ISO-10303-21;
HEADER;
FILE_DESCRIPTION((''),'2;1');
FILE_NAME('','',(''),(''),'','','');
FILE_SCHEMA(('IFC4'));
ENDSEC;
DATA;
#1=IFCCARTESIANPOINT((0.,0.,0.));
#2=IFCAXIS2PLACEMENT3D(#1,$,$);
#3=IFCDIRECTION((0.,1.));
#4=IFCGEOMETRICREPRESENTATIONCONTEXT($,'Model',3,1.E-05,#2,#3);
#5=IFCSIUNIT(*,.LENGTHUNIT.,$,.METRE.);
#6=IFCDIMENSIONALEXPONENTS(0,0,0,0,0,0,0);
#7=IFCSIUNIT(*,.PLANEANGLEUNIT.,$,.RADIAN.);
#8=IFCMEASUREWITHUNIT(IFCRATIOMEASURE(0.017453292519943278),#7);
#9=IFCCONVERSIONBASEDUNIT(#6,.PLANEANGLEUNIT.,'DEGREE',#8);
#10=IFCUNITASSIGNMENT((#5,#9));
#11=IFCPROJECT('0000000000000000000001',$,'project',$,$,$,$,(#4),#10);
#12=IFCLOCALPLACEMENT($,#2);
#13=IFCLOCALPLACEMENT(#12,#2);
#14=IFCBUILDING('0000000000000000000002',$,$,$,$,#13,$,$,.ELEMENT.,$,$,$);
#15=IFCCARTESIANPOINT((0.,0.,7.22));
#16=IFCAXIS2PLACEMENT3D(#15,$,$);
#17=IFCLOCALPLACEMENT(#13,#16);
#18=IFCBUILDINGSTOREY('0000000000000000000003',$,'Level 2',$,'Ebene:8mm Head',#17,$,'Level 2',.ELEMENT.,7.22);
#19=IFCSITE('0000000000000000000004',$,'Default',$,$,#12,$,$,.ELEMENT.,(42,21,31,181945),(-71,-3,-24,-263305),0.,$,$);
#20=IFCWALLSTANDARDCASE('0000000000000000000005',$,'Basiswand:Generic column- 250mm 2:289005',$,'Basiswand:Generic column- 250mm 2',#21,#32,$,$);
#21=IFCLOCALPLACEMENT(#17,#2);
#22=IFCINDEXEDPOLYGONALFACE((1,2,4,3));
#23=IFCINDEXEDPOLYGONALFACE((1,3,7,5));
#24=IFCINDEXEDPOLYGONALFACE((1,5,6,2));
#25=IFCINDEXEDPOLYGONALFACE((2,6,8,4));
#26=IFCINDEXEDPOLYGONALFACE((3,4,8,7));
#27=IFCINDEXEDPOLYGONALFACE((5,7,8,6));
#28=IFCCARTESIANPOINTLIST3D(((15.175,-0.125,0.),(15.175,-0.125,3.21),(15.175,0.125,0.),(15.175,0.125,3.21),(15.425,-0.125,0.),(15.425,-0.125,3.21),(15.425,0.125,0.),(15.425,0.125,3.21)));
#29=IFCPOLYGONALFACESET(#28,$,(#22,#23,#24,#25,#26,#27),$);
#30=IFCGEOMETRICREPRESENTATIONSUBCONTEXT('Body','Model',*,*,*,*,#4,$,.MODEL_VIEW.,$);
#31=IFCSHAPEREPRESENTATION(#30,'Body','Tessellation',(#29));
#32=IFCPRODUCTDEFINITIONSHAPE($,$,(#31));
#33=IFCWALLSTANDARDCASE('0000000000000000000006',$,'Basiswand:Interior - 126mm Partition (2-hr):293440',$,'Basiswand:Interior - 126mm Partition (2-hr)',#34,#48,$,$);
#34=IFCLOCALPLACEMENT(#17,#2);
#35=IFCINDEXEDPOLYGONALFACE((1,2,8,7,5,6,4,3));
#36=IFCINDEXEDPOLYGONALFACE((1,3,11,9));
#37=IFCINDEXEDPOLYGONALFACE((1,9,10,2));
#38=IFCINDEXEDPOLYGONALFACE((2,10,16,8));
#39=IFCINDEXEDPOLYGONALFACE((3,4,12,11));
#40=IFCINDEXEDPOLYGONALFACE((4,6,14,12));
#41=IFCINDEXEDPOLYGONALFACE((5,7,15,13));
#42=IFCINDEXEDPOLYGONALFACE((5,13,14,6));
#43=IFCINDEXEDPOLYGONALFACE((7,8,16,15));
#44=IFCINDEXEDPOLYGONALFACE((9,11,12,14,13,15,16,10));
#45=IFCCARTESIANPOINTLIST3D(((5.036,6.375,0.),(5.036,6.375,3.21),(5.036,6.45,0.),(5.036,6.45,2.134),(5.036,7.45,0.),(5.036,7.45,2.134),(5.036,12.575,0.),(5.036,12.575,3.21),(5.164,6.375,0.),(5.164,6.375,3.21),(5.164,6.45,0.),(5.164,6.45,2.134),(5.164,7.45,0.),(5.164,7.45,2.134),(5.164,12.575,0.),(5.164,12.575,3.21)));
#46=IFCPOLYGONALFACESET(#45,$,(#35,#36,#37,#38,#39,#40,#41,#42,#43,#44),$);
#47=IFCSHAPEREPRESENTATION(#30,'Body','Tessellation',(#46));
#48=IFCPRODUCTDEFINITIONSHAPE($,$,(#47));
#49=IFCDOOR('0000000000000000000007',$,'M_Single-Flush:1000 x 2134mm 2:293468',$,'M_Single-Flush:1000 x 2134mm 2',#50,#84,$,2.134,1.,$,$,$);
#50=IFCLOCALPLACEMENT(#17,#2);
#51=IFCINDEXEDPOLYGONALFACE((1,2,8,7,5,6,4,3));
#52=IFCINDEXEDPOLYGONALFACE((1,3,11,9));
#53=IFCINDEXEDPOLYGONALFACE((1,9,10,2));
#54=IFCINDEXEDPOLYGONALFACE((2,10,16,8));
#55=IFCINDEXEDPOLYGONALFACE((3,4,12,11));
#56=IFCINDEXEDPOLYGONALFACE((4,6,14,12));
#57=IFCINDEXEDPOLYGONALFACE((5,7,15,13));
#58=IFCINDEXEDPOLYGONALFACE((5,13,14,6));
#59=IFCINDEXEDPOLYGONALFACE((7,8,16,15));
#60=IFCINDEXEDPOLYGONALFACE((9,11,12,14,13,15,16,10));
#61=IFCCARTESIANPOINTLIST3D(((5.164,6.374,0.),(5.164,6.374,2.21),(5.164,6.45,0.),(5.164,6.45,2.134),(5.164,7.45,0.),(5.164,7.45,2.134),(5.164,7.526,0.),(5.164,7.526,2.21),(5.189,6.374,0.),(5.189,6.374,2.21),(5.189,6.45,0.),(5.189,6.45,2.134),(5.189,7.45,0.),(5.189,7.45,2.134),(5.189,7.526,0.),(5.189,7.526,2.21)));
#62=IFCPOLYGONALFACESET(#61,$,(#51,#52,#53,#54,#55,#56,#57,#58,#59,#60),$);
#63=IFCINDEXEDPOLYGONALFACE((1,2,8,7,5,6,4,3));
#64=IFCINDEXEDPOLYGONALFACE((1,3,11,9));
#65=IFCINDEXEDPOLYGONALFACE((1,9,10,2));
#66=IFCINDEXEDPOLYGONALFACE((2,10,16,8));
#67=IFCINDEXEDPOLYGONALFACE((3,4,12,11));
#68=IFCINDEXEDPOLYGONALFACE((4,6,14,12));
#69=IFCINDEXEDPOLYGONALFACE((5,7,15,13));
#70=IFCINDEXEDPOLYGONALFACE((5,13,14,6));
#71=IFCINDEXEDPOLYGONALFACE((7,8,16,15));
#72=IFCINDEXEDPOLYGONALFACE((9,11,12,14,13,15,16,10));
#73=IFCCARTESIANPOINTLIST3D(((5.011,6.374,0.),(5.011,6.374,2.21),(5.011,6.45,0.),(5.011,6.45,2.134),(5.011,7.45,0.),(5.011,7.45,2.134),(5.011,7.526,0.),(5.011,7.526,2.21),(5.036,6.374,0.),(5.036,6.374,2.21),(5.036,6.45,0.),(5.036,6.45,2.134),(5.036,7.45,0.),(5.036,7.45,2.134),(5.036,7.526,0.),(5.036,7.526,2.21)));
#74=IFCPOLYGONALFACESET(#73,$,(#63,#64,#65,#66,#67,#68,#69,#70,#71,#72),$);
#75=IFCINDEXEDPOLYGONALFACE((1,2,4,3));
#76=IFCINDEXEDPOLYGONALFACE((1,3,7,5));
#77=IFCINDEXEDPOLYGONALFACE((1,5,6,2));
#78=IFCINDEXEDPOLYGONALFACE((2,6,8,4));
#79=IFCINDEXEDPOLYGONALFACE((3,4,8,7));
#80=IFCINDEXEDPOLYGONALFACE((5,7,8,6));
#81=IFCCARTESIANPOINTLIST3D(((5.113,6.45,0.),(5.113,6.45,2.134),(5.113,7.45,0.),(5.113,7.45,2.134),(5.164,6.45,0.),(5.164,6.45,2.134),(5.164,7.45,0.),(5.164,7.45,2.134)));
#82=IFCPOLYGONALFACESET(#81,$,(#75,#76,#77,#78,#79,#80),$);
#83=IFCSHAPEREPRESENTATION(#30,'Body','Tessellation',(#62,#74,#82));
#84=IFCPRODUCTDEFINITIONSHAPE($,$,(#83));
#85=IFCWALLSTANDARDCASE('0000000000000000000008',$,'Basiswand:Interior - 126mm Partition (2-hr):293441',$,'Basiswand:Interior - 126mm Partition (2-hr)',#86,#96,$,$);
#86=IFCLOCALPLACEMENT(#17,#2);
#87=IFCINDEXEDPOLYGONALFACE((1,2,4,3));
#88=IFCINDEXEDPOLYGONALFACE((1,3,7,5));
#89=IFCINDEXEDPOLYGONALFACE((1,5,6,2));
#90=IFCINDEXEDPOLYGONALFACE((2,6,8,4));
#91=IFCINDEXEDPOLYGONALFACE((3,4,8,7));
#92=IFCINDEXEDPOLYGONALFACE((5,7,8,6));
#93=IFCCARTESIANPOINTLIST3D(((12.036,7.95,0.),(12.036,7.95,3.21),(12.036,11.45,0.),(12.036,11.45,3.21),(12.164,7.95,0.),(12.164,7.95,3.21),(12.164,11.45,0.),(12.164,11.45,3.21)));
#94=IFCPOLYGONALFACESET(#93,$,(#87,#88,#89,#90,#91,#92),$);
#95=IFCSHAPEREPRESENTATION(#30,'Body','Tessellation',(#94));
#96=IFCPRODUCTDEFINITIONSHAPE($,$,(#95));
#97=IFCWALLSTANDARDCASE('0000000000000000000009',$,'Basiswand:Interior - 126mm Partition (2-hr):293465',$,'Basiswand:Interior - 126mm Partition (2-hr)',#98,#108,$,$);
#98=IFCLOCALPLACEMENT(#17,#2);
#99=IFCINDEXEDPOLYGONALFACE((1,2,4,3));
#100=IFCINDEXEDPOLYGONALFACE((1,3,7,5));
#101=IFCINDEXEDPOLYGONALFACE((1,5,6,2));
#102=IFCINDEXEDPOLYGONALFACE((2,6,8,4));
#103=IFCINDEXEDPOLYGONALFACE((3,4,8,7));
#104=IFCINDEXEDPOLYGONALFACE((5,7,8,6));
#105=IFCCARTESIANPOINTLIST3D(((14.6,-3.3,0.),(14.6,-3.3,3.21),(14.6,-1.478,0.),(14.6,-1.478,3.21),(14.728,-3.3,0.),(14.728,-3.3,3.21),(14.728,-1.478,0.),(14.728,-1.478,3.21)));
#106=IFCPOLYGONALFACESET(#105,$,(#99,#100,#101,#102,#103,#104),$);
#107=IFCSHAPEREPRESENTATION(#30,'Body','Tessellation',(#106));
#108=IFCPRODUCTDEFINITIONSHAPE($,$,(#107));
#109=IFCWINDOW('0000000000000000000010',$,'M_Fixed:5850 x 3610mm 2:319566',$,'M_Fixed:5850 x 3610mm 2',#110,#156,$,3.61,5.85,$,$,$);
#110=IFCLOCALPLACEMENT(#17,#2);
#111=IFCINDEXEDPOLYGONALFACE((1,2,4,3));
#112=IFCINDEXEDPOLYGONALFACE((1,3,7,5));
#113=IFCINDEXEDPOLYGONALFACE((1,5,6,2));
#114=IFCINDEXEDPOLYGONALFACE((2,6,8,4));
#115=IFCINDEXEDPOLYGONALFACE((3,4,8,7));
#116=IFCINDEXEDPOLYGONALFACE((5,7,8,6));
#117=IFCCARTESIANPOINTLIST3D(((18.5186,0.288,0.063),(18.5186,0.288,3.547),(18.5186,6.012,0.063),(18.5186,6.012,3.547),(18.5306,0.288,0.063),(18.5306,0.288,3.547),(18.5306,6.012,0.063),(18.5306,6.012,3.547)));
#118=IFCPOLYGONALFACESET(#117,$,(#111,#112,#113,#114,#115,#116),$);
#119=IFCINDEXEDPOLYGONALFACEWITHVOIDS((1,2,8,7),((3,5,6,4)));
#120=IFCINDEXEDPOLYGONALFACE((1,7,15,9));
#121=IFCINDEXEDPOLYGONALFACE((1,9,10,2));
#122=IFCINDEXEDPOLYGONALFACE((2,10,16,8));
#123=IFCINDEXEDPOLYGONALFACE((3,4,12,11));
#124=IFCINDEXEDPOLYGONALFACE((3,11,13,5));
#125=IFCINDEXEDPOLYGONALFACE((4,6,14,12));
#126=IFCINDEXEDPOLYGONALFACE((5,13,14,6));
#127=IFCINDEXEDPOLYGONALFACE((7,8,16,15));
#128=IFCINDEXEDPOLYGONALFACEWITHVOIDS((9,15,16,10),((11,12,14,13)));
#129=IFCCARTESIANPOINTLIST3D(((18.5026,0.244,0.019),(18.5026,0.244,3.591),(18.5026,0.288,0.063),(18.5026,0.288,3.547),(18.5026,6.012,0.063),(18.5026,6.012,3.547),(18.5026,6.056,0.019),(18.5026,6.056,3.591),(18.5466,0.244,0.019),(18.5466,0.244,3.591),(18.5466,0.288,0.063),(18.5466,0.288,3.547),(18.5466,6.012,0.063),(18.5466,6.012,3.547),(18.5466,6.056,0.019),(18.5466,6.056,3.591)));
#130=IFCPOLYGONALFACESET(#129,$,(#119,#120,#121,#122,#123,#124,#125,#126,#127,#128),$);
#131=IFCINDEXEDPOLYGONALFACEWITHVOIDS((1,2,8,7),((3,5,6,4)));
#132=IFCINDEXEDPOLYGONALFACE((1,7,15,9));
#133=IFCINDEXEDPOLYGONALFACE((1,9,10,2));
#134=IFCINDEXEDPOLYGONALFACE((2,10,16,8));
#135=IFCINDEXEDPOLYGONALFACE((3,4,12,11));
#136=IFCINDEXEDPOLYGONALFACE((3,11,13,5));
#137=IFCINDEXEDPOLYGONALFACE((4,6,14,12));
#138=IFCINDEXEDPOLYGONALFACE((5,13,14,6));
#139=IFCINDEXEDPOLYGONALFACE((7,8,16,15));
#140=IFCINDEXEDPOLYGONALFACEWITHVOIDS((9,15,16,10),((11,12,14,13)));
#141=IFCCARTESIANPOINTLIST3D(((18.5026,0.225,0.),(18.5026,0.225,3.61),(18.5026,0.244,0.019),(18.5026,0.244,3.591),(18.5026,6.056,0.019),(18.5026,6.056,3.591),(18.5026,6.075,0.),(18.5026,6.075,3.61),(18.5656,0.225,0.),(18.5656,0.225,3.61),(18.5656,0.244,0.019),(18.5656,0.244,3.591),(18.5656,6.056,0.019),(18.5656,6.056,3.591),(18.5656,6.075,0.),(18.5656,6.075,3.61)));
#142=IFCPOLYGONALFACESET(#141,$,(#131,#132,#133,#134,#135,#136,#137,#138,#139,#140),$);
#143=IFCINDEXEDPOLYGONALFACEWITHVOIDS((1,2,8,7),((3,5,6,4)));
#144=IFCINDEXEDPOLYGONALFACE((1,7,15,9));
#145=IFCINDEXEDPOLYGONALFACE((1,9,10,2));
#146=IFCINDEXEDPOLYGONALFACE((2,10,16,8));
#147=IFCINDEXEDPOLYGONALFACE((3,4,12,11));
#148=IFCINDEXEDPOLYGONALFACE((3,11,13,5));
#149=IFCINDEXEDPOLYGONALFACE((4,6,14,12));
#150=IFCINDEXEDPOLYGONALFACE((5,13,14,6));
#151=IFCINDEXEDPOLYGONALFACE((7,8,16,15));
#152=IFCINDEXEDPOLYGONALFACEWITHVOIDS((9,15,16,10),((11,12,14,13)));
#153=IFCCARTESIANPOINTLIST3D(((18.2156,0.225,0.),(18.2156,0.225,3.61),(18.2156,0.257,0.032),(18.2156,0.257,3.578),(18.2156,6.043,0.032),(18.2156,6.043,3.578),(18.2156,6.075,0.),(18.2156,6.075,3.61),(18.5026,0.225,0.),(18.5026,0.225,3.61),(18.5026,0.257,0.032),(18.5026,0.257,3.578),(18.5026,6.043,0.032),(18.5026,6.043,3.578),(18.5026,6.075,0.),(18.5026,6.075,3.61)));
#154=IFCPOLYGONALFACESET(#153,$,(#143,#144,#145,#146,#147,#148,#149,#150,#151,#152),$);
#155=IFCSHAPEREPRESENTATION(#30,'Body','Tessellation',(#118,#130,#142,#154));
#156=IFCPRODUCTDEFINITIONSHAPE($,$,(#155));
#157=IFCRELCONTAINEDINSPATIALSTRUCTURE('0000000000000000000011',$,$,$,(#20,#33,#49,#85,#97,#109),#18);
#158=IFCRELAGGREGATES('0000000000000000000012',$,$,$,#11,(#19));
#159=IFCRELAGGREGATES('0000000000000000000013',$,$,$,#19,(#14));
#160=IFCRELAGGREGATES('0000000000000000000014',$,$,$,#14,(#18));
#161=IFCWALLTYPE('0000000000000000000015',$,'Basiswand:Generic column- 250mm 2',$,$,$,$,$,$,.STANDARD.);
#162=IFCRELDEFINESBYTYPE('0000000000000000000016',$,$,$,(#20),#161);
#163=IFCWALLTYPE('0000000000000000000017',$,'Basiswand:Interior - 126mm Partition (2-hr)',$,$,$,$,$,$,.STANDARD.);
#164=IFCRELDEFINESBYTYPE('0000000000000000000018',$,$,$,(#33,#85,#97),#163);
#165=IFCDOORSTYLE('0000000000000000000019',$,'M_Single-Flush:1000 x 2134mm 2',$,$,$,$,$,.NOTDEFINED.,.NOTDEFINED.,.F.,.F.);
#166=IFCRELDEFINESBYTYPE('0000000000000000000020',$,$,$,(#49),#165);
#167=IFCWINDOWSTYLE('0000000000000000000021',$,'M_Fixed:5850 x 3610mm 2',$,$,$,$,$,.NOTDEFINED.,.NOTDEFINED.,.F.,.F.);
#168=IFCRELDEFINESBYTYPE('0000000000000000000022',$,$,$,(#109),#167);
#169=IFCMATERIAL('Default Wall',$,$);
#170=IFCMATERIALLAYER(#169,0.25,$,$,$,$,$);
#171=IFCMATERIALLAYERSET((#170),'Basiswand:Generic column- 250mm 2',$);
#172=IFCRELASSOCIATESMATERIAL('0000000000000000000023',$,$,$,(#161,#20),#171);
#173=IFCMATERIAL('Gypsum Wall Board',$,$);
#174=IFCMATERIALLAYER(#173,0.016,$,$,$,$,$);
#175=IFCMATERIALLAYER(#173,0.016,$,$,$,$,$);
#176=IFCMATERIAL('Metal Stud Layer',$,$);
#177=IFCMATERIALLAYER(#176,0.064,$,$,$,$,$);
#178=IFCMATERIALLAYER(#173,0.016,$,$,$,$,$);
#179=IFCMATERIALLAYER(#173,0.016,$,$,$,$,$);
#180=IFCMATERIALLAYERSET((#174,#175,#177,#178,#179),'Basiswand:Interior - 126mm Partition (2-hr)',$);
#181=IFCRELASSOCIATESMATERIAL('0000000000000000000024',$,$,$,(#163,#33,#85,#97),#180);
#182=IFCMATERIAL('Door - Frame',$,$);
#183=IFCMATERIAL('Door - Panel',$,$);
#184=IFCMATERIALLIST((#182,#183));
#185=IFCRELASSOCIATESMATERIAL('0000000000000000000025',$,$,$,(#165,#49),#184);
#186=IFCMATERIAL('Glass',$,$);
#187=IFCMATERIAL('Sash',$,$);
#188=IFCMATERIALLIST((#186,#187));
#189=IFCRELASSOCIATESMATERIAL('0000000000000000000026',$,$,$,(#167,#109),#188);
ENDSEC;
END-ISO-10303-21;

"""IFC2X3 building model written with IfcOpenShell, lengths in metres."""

from ifc_helpers import new_model, entity, si_unit, converted_unit, direction, frame, frame_2d, origin, place, context, subcontext, project, spatial, polyline, rectangle, outline, extrude, clip, bounded_halfspace, source, transform, mapped, material, material_list, layer, layer_set, layer_usage, type_object, type_shapes, element, fill, save


model = new_model("IFC2X3")

# Units and contexts
model_context = context("Model", 3, precision=1e-05, world=origin(), true_north=direction((0.0, 1.0)))
body_context = subcontext(model_context, "Body", "Model", "MODEL_VIEW")
ifc_project = project(units=[si_unit("LENGTHUNIT", "METRE"), converted_unit("PLANEANGLEUNIT", "DEGREE", entity("IfcRatioMeasure", 0.017453292519943278), si_unit("PLANEANGLEUNIT", "RADIAN"), dimensions=[0, 0, 0, 0, 0, 0, 0])], contexts=[model_context])

# Site, building, storey
site_placement = place(None, origin())
site = spatial("IfcSite", under=ifc_project, at=site_placement, Name="Default", CompositionType="ELEMENT", RefLatitude=(42, 21, 31, 181945), RefLongitude=(-71, -3, -24, -263305), RefElevation=0.0)
building_placement = place(site_placement, origin())
building = spatial("IfcBuilding", under=site, at=building_placement, CompositionType="ELEMENT")
storey_placement = place(building_placement, frame((0.0, 0.0, 7.22)))
storey = spatial("IfcBuildingStorey", under=building, at=storey_placement, Name="Level 2", ObjectType="Ebene:8mm Head", LongName="Level 2", CompositionType="ELEMENT", Elevation=7.22)

# Shared definitions
ifc_material_1 = material(Name="Default Wall")
ifc_material_2 = material(Name="Door - Frame")
ifc_material_3 = material(Name="Door - Panel")
ifc_material_list_1 = material_list([ifc_material_2, ifc_material_3])

# Wall
ifc_layer_1 = layer(ifc_material_1, 0.25)
ifc_layer_set_1 = layer_set([ifc_layer_1], Name="Basiswand:Generic column- 250mm 2")
ifc_layer_usage_1 = layer_usage(ifc_layer_set_1, "AXIS2", "NEGATIVE", 0.125)
wall_type_1 = type_object("IfcWallType", Name="Basiswand:Generic column- 250mm 2", PredefinedType="STANDARD", material=ifc_layer_set_1)
for number, where, name in (
    (1, (15.175, 0.0, 0.0), "Basiswand:Generic column- 250mm 2:289005"),
):
    element("IfcWallStandardCase", number, at=place(storey_placement, frame(where)), inside=storey, type_object=wall_type_1, material=ifc_layer_usage_1, Name=name, ObjectType="Basiswand:Generic column- 250mm 2", context=body_context, shape_type="Clipping", body=[
        clip(extrude(rectangle(XDim=0.25, YDim=0.25, at=frame_2d((0.125, 0.0), x_axis=(-1.0, 0.0))), origin(), (0.0, 0.0, 1.0), 3.21), bounded_halfspace(frame((0.0, -0.125, 3.21), z_axis=(0.0, 0.0, -1.0), x_axis=(0.0, 1.0, 0.0)), True, frame((0.0, -0.125, 3.21), z_axis=(0.0, 0.0, -1.0), x_axis=(0.0, 1.0, 0.0)), polyline([(0.0, 0.0), (0.25, 0.0), (0.25, 0.25), (0.0, 0.25), (0.0, 0.0)]))),
    ])

# Wall, opening, door
ifc_material_4 = material(Name="Gypsum Wall Board")
ifc_layer_2 = layer(ifc_material_4, 0.016)
ifc_layer_3 = layer(ifc_material_4, 0.016)
ifc_material_5 = material(Name="Metal Stud Layer")
ifc_layer_4 = layer(ifc_material_5, 0.064)
ifc_layer_5 = layer(ifc_material_4, 0.016)
ifc_layer_6 = layer(ifc_material_4, 0.016)
ifc_layer_set_2 = layer_set([ifc_layer_2, ifc_layer_3, ifc_layer_4, ifc_layer_5, ifc_layer_6], Name="Basiswand:Interior - 126mm Partition (2-hr)")
ifc_layer_usage_2 = layer_usage(ifc_layer_set_2, "AXIS2", "NEGATIVE", 0.064)
wall_type_2 = type_object("IfcWallType", Name="Basiswand:Interior - 126mm Partition (2-hr)", PredefinedType="STANDARD", material=ifc_layer_set_2)
wall_1_placement = place(storey_placement, frame((5.1, 6.375, 0.0), z_axis=(0.0, 0.0, 1.0), x_axis=(0.0, 1.0, 0.0)))
wall_1 = element("IfcWallStandardCase", 2, at=wall_1_placement, inside=storey, type_object=wall_type_2, material=ifc_layer_usage_2, Name="Basiswand:Interior - 126mm Partition (2-hr):293440", ObjectType="Basiswand:Interior - 126mm Partition (2-hr)", context=body_context, shape_type="Clipping", body=[
    clip(extrude(rectangle(XDim=6.2, YDim=0.128, at=frame_2d((3.1, 0.0), x_axis=(1.0, 0.0))), origin(), (0.0, 0.0, 1.0), 3.21), bounded_halfspace(frame((0.0, -0.064, 3.21), z_axis=(0.0, 0.0, -1.0), x_axis=(1.0, 0.0, 0.0)), True, frame((0.0, -0.064, 3.21)), polyline([(0.0, 0.0), (6.2, 0.0), (6.2, 0.128), (0.0, 0.128), (0.0, 0.0)]))),
])
opening_1_placement = place(wall_1_placement, frame((1.075, 0.064, 0.0)))
opening_1 = element("IfcOpeningElement", 3, at=opening_1_placement, cuts=wall_1, ObjectType="Opening", context=body_context, shape_type="SweptSolid", body=[
    extrude(rectangle(XDim=1.0, YDim=2.134, at=frame_2d((1.067, 0.5), x_axis=(0.0, 1.0))), frame((0.0, 0.0, 0.0), z_axis=(0.0, -1.0, 0.0), x_axis=(0.0, 0.0, 1.0)), (0.0, 0.0, 1.0), 0.128),
])
door_style_1 = type_object("IfcDoorStyle", Name="M_Single-Flush:1000 x 2134mm 2", ConstructionType="NOTDEFINED", OperationType="NOTDEFINED", ParameterTakesPrecedence=False, Sizeable=False, material=ifc_material_list_1)
shared_shape_1 = source(origin(), body_context, "Body", "SweptSolid", [
    extrude(outline(polyline([(-0.576, -1.124), (0.576, -1.124), (0.576, 1.086), (0.5, 1.086), (0.5, -1.048), (-0.5, -1.048), (-0.5, 1.086), (-0.576, 1.086), (-0.576, -1.124)])), frame((0.5, 0.128, 1.086), z_axis=(0.0, 1.0, 0.0), x_axis=(1.0, 0.0, 0.0)), (0.0, 0.0, 1.0), 0.025),
    extrude(outline(polyline([(-1.124, -0.576), (1.086, -0.576), (1.086, -0.5), (-1.048, -0.5), (-1.048, 0.5), (1.086, 0.5), (1.086, 0.576), (-1.124, 0.576), (-1.124, -0.576)])), frame((0.5, -0.025, 1.086), z_axis=(0.0, 1.0, 0.0), x_axis=(0.0, 0.0, -1.0)), (0.0, 0.0, 1.0), 0.025),
    extrude(rectangle(XDim=0.051, YDim=1.0, at=frame_2d((0.0, 0.0), x_axis=(1.0, 0.0))), frame((0.5, 0.1025, 0.0), z_axis=(0.0, 0.0, 1.0), x_axis=(0.0, 1.0, 0.0)), (0.0, 0.0, 1.0), 2.134),
])
type_shapes(door_style_1, [shared_shape_1])
door_1_placement = place(opening_1_placement, frame((0.0, 0.0, 0.0), z_axis=(0.0, 0.0, 1.0), x_axis=(-1.0, 0.0, 0.0)))
door_1 = element("IfcDoor", 4, at=door_1_placement, inside=storey, type_object=door_style_1, material=ifc_material_list_1, Name="M_Single-Flush:1000 x 2134mm 2:293468", ObjectType="M_Single-Flush:1000 x 2134mm 2", OverallHeight=2.134, OverallWidth=1.0, context=body_context, shape_type="MappedRepresentation", body=[
    mapped(shared_shape_1, transform((0.0, 0.0, 0.0), scale=1.0)),
])
fill(opening_1, door_1)

# Wall
wall_2_placement = place(storey_placement, frame((12.1, 7.95, 0.0), z_axis=(0.0, 0.0, 1.0), x_axis=(0.0, 1.0, 0.0)))
element("IfcWallStandardCase", 5, at=wall_2_placement, inside=storey, type_object=wall_type_2, material=ifc_layer_usage_2, Name="Basiswand:Interior - 126mm Partition (2-hr):293441", ObjectType="Basiswand:Interior - 126mm Partition (2-hr)", context=body_context, shape_type="Clipping", body=[
    clip(extrude(rectangle(XDim=3.5, YDim=0.128, at=frame_2d((1.75, 0.0), x_axis=(-1.0, 0.0))), origin(), (0.0, 0.0, 1.0), 3.21), bounded_halfspace(frame((0.0, -0.064, 3.21), z_axis=(0.0, 0.0, -1.0), x_axis=(1.0, 0.0, 0.0)), True, frame((0.0, -0.064, 3.21)), polyline([(0.0, 0.0), (3.5, 0.0), (3.5, 0.128), (0.0, 0.128), (0.0, 0.0)]))),
])

# Wall
wall_3_placement = place(storey_placement, frame((14.664, -3.3, 0.0), z_axis=(0.0, 0.0, 1.0), x_axis=(0.0, 1.0, 0.0)))
element("IfcWallStandardCase", 6, at=wall_3_placement, inside=storey, type_object=wall_type_2, material=ifc_layer_usage_2, Name="Basiswand:Interior - 126mm Partition (2-hr):293465", ObjectType="Basiswand:Interior - 126mm Partition (2-hr)", context=body_context, shape_type="Clipping", body=[
    clip(extrude(rectangle(XDim=1.822, YDim=0.128, at=frame_2d((0.911, 0.0), x_axis=(-1.0, 0.0))), origin(), (0.0, 0.0, 1.0), 3.21), bounded_halfspace(frame((0.0, -0.064, 3.21), z_axis=(0.0, 0.0, -1.0), x_axis=(1.0, 0.0, 0.0)), True, frame((0.0, -0.064, 3.21)), polyline([(0.0, 0.0), (1.822, 0.0), (1.822, 0.128), (0.0, 0.128), (0.0, 0.0)]))),
])

# Window
ifc_material_6 = material(Name="Glass")
ifc_material_7 = material(Name="Sash")
ifc_material_list_2 = material_list([ifc_material_6, ifc_material_7])
window_style = type_object("IfcWindowStyle", Name="M_Fixed:5850 x 3610mm 2", ConstructionType="NOTDEFINED", OperationType="NOTDEFINED", ParameterTakesPrecedence=False, Sizeable=False, material=ifc_material_list_2)
shared_shape_2 = source(origin(), body_context, "Body", "SweptSolid", [
    extrude(rectangle(XDim=0.012, YDim=5.724, at=frame_2d((0.0, 0.0), x_axis=(1.0, 0.0))), frame((2.925, 0.309, 0.063), z_axis=(0.0, 0.0, 1.0), x_axis=(0.0, -1.0, 0.0)), (0.0, 0.0, 1.0), 3.484),
    extrude(outline(polyline([(-2.906, -1.786), (2.906, -1.786), (2.906, 1.786), (-2.906, 1.786), (-2.906, -1.786)]), holes=[polyline([(-2.862, -1.742), (-2.862, 1.742), (2.862, 1.742), (2.862, -1.742), (-2.862, -1.742)])]), frame((2.925, 0.287, 1.805), z_axis=(0.0, 1.0, 0.0), x_axis=(1.0, 0.0, 0.0)), (0.0, 0.0, 1.0), 0.044),
    extrude(outline(polyline([(-2.925, -1.805), (2.925, -1.805), (2.925, 1.805), (-2.925, 1.805), (-2.925, -1.805)]), holes=[polyline([(-2.906, -1.786), (-2.906, 1.786), (2.906, 1.786), (2.906, -1.786), (-2.906, -1.786)])]), frame((2.925, 0.287, 1.805), z_axis=(0.0, 1.0, 0.0), x_axis=(1.0, 0.0, 0.0)), (0.0, 0.0, 1.0), 0.063),
    extrude(outline(polyline([(-2.925, -1.805), (2.925, -1.805), (2.925, 1.805), (-2.925, 1.805), (-2.925, -1.805)]), holes=[polyline([(-2.893, -1.773), (-2.893, 1.773), (2.893, 1.773), (2.893, -1.773), (-2.893, -1.773)])]), frame((2.925, 0.0, 1.805), z_axis=(0.0, 1.0, 0.0), x_axis=(1.0, 0.0, 0.0)), (0.0, 0.0, 1.0), 0.287),
])
type_shapes(window_style, [shared_shape_2])
window_placement = place(storey_placement, frame((18.2156, 6.075, 0.0), z_axis=(0.0, 0.0, 1.0), x_axis=(0.0, -1.0, 0.0)))
element("IfcWindow", 7, at=window_placement, inside=storey, type_object=window_style, material=ifc_material_list_2, Name="M_Fixed:5850 x 3610mm 2:319566", ObjectType="M_Fixed:5850 x 3610mm 2", OverallHeight=3.61, OverallWidth=5.85, context=body_context, shape_type="MappedRepresentation", body=[
    mapped(shared_shape_2, transform((0.0, 0.0, 0.0), scale=1.0)),
])

save(model, "model.ifc")
